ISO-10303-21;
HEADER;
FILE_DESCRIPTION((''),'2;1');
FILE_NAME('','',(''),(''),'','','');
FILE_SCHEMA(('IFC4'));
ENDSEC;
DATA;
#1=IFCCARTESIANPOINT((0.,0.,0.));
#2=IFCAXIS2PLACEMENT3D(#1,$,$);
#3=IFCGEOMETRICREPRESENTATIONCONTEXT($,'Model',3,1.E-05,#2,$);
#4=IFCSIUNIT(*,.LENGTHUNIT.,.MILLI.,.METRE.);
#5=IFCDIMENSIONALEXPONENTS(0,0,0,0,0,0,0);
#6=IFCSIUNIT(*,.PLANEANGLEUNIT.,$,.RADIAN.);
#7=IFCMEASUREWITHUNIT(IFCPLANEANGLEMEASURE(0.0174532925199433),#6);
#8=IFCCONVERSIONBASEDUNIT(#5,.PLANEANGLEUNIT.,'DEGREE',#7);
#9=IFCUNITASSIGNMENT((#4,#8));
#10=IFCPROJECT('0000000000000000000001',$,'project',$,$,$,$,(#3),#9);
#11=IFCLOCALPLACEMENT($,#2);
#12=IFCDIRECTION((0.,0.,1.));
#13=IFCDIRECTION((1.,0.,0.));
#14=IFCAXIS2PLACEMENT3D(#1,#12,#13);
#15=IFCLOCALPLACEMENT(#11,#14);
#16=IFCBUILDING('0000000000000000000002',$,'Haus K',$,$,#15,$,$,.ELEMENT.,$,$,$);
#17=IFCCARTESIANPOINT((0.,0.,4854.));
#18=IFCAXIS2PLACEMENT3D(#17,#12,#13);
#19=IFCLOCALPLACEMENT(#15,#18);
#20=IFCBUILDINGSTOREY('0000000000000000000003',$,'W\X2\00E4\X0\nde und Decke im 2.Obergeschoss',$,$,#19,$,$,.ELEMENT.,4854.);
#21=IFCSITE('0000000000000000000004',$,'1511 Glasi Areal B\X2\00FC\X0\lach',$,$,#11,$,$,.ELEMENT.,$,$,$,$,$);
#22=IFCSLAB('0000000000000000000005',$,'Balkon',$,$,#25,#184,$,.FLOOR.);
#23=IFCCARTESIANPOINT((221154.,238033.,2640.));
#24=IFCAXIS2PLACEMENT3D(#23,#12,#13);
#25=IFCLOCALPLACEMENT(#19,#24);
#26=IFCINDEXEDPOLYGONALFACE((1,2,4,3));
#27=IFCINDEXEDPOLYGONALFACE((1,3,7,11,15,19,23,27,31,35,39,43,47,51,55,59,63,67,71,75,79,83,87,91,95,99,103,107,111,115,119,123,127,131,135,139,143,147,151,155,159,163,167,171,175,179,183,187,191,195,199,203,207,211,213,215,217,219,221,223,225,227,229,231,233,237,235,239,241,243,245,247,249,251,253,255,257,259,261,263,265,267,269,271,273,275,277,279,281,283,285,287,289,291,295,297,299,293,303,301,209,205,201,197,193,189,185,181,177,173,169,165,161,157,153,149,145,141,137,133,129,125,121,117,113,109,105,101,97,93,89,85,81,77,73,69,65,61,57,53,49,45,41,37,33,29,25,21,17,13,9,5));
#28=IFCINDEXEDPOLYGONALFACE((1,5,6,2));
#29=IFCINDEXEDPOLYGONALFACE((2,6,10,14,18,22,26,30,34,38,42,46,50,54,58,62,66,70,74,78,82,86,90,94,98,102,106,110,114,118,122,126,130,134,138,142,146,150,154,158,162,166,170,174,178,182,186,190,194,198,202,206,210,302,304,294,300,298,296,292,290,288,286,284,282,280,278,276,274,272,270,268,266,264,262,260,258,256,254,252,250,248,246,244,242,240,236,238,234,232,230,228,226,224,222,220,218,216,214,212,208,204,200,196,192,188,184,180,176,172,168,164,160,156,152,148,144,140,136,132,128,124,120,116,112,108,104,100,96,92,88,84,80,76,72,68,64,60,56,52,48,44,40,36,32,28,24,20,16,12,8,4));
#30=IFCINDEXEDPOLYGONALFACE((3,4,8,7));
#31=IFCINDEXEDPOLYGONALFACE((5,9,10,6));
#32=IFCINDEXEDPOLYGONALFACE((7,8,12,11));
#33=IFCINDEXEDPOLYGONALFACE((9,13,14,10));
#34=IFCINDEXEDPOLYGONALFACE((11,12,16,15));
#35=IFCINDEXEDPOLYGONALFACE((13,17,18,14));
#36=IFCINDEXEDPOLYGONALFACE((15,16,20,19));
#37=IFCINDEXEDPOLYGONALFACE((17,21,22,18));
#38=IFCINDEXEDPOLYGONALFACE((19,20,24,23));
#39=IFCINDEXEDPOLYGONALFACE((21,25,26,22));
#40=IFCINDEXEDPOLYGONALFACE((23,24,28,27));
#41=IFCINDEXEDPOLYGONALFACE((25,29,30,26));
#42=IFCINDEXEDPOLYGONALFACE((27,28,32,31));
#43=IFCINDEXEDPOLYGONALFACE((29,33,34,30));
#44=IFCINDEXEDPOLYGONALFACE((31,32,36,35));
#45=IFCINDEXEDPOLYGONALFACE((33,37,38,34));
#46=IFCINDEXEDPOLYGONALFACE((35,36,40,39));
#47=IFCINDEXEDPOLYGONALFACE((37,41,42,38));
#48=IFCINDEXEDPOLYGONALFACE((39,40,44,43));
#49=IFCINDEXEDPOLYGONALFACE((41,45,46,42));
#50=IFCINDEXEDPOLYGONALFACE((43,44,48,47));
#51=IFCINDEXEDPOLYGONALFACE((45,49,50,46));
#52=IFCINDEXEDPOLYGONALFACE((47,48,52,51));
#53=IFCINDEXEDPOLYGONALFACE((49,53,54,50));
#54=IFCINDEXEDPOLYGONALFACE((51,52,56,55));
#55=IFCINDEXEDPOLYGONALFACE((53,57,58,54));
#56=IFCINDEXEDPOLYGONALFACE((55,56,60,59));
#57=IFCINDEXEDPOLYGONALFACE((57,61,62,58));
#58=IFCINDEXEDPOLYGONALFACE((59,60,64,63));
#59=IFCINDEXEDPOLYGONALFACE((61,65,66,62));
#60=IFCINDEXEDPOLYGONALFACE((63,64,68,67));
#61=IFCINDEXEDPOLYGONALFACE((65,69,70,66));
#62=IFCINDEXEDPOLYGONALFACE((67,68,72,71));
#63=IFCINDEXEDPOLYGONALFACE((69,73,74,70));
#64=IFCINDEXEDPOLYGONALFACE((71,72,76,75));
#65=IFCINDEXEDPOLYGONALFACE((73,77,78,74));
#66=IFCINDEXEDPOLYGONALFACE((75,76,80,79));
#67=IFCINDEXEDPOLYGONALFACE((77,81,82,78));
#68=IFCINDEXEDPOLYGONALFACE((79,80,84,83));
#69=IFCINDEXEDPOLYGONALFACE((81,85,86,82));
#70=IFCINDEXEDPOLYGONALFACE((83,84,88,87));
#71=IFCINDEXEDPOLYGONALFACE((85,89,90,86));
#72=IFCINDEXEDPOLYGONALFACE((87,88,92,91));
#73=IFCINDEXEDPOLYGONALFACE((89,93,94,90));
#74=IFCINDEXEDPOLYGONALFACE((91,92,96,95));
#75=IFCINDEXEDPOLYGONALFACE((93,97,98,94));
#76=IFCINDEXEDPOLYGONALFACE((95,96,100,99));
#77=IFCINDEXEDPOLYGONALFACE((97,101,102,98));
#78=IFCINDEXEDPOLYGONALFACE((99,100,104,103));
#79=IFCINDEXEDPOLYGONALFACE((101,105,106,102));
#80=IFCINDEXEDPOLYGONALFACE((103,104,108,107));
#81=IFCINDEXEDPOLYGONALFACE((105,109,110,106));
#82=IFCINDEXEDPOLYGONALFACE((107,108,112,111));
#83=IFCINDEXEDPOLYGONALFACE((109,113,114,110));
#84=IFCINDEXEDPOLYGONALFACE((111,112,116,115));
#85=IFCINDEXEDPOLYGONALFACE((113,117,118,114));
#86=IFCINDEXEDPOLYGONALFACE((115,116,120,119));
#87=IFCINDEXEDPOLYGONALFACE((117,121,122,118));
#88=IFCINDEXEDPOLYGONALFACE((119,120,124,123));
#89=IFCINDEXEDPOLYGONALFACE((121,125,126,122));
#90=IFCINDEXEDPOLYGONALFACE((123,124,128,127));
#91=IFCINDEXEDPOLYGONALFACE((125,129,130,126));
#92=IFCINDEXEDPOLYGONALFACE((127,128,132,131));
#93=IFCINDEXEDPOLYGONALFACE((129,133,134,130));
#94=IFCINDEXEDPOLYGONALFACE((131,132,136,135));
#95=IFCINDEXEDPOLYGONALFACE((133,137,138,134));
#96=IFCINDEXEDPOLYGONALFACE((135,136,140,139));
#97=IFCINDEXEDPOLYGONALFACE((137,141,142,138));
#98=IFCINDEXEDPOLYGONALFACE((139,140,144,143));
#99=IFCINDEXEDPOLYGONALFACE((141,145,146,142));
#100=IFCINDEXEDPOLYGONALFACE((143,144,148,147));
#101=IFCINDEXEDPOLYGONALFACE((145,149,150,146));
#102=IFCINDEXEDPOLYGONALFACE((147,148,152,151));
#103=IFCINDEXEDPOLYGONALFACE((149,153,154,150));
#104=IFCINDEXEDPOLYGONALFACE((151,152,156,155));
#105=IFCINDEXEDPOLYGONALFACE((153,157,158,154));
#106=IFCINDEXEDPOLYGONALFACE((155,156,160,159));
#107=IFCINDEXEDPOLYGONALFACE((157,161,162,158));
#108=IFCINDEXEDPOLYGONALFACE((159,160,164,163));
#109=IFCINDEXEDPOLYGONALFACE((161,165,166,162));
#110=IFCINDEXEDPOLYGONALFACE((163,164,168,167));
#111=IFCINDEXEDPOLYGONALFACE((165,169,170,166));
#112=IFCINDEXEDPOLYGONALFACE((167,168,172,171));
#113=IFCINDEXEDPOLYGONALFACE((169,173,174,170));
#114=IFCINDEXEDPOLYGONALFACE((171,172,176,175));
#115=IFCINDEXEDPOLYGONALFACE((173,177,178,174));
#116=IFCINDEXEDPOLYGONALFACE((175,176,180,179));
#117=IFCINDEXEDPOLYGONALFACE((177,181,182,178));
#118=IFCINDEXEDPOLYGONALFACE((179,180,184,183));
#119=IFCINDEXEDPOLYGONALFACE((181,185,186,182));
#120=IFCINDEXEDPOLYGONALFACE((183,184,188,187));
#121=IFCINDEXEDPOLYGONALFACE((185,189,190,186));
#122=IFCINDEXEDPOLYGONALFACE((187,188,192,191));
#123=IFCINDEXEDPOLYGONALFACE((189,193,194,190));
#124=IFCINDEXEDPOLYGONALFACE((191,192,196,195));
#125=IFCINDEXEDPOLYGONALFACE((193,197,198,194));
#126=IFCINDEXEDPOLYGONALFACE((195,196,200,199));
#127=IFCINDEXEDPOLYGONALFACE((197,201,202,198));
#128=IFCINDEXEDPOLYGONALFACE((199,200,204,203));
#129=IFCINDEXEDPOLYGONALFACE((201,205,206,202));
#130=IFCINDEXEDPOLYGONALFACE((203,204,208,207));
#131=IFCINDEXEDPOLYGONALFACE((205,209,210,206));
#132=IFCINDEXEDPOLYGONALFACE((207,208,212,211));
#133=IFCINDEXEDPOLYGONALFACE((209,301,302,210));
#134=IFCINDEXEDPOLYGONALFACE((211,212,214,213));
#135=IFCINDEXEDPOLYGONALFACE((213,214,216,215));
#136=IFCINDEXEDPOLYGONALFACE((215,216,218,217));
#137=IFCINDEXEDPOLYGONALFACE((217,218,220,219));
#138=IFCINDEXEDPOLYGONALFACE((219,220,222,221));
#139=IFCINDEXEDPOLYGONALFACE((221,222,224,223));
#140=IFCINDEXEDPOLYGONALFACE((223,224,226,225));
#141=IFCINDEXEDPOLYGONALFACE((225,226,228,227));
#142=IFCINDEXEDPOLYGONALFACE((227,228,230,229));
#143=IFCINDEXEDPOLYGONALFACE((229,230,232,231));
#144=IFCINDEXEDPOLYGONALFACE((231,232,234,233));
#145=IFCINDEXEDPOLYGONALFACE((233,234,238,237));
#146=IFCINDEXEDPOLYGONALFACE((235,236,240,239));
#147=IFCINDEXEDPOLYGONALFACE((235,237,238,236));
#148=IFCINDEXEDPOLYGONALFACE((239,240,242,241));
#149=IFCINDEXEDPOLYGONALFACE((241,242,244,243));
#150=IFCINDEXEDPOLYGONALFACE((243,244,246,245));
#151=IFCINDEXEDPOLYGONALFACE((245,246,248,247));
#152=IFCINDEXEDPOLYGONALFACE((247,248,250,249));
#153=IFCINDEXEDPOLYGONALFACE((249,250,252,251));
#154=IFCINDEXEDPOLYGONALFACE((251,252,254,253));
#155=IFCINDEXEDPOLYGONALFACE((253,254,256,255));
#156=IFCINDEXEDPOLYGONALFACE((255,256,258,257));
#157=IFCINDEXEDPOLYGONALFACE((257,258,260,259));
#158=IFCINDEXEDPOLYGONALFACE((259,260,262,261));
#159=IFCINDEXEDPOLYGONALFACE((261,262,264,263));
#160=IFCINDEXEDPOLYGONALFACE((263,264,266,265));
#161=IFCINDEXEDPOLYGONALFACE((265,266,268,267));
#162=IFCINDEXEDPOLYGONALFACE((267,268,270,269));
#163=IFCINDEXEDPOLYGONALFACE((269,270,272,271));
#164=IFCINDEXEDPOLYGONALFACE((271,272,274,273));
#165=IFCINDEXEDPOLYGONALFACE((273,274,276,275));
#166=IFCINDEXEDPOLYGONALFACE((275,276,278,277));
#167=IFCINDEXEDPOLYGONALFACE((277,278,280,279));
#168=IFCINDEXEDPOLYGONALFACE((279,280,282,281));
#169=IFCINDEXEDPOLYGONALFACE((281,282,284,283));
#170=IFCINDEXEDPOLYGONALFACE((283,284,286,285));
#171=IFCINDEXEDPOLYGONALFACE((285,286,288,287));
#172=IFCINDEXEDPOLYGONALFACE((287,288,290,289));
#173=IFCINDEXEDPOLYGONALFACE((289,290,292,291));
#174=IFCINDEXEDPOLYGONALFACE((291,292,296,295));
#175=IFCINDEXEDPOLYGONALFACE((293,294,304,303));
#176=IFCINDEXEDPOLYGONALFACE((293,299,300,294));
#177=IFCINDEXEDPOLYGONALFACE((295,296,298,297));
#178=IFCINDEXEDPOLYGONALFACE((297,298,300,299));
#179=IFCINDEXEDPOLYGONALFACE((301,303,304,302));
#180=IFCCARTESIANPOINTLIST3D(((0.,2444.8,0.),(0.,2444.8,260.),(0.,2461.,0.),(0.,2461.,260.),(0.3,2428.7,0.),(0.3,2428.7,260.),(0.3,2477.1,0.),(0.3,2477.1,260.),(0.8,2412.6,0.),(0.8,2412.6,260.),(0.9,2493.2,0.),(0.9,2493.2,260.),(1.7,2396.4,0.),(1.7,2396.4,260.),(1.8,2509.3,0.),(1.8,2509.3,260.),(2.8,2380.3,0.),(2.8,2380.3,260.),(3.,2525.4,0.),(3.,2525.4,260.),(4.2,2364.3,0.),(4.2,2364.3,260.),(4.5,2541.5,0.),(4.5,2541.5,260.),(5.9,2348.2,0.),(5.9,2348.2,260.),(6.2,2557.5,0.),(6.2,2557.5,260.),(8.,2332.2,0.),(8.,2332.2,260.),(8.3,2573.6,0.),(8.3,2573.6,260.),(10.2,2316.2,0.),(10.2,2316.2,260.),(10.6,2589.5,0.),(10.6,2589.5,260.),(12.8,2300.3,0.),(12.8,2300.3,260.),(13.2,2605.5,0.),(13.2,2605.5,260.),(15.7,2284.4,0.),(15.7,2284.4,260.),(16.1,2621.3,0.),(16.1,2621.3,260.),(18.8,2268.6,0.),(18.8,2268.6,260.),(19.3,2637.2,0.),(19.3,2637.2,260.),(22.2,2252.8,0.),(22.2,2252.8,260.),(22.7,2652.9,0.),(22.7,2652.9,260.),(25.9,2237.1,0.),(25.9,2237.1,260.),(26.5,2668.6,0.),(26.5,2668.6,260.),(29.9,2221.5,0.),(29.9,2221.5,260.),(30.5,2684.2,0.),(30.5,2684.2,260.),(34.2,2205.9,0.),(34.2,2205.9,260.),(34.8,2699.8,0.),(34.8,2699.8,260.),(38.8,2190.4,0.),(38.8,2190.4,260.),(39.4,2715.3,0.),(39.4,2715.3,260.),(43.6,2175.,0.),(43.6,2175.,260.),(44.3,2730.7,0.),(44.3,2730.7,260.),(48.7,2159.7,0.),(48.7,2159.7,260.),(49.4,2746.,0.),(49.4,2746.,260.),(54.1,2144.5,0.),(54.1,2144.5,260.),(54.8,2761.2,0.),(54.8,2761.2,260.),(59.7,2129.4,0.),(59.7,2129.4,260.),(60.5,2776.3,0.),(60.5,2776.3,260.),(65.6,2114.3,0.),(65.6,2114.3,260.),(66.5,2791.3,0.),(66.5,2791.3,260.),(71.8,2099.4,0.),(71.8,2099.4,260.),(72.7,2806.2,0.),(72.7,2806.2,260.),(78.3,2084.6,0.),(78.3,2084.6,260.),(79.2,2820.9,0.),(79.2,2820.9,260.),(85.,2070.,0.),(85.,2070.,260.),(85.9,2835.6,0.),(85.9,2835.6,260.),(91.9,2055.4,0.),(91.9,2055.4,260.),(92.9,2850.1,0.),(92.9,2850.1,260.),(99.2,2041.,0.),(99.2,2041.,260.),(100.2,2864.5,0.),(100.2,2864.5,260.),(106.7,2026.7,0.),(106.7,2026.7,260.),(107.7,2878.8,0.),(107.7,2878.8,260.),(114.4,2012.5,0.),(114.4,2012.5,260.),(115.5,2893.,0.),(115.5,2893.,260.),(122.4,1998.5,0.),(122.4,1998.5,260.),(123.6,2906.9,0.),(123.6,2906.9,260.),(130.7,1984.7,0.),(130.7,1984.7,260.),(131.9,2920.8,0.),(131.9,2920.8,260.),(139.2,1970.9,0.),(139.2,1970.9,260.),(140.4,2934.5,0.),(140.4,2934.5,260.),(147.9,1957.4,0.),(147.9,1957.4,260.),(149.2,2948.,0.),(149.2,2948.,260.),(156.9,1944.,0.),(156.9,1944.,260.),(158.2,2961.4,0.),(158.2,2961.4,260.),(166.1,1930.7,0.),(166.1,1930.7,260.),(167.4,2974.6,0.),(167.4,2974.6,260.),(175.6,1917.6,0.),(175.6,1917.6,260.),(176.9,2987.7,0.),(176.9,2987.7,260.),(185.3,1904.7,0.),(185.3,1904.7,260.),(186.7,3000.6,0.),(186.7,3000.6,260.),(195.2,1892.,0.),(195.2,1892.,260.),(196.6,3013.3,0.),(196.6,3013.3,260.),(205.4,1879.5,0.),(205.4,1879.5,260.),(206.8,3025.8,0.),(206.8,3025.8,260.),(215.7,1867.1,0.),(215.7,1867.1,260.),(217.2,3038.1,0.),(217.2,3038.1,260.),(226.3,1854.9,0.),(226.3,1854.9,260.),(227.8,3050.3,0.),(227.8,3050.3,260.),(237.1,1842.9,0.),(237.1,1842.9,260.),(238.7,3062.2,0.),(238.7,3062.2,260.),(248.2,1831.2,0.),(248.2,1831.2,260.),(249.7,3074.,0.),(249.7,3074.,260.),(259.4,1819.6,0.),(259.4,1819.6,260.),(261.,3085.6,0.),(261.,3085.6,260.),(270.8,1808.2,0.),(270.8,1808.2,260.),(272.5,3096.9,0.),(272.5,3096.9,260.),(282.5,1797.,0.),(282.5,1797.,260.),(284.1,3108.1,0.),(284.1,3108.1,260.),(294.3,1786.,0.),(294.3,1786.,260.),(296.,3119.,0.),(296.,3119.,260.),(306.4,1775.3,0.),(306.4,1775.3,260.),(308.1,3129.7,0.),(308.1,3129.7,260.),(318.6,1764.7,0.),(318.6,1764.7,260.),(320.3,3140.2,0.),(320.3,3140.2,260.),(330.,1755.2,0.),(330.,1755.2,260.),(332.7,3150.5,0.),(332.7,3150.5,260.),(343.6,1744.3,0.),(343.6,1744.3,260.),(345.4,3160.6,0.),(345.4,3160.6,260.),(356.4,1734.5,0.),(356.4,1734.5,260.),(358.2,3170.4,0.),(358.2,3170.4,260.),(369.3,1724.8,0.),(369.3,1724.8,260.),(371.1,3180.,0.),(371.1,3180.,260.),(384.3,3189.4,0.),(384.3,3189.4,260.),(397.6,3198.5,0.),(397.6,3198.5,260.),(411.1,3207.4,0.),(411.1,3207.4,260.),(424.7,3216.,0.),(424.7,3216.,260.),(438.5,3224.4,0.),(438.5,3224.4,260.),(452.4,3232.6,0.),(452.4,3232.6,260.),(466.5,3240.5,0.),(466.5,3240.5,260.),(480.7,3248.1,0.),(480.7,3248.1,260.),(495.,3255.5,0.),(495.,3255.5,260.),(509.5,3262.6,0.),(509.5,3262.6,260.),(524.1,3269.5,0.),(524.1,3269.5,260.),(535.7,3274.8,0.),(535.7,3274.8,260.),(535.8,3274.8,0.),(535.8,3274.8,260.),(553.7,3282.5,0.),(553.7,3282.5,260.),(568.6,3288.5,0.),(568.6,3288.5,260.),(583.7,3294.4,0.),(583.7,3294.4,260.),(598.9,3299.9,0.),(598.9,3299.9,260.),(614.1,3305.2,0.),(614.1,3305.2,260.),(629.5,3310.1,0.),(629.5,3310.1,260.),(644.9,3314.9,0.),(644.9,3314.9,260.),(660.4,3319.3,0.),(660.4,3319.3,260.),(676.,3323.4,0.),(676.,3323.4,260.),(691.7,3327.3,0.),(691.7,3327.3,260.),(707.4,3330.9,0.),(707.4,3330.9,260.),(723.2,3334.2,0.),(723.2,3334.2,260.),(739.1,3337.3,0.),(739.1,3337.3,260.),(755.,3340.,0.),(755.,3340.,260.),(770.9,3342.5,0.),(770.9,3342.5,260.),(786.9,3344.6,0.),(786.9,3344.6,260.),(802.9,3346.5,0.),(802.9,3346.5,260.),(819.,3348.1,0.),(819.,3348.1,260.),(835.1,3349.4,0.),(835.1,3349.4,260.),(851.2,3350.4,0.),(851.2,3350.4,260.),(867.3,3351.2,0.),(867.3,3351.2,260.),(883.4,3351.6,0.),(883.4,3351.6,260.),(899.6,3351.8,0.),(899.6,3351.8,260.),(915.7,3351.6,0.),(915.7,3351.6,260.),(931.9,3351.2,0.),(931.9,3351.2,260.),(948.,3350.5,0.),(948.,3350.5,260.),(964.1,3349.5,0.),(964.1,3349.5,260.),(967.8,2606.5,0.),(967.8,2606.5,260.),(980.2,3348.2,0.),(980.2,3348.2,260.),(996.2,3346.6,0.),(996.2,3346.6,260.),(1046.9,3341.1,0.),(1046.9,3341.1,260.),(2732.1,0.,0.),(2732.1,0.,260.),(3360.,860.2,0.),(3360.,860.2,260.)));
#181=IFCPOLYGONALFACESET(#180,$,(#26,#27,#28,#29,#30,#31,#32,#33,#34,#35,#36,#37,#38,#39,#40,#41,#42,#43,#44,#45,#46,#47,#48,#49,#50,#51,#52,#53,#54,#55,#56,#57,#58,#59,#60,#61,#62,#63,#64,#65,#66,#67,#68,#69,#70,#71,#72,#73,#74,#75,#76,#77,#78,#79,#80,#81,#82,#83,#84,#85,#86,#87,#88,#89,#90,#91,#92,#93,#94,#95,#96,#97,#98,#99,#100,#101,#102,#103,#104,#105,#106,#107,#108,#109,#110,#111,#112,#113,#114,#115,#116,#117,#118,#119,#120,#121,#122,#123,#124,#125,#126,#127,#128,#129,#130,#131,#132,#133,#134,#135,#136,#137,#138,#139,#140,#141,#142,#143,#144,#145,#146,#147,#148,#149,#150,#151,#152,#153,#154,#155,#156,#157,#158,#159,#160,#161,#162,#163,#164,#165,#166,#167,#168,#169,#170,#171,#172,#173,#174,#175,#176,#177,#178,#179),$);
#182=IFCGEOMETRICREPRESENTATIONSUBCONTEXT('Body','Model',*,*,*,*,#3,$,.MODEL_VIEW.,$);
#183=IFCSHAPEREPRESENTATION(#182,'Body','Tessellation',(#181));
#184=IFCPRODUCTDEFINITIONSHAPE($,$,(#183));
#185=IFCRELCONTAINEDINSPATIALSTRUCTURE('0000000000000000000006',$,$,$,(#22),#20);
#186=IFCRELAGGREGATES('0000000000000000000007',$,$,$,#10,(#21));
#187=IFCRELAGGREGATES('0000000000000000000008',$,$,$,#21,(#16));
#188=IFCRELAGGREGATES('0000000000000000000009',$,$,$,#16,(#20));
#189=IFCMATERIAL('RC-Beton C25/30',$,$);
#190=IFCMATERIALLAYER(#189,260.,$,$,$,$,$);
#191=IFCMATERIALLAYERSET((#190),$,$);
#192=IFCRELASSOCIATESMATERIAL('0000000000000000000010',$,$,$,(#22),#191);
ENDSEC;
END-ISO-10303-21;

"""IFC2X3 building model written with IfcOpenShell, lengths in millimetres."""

from ifc_helpers import new_model, entity, si_unit, converted_unit, frame, origin, origin_with_axes, place, context, subcontext, project, spatial, polyline, outline, extrude, material, layer, layer_set, layer_usage, element, save


model = new_model("IFC2X3")

# Units and contexts
model_context = context("Model", 3, precision=1e-05, world=origin())
body_context = subcontext(model_context, "Body", "Model", "MODEL_VIEW")
ifc_project = project(units=[si_unit("LENGTHUNIT", "METRE", prefix="MILLI"), converted_unit("PLANEANGLEUNIT", "DEGREE", entity("IfcPlaneAngleMeasure", 0.0174532925199433), si_unit("PLANEANGLEUNIT", "RADIAN"), dimensions=[0, 0, 0, 0, 0, 0, 0])], contexts=[model_context])

# Site, building, storey
site_placement = place(None, origin())
site = spatial("IfcSite", under=ifc_project, at=site_placement, Name="1511 Glasi Areal Bülach", CompositionType="ELEMENT")
building_placement = place(site_placement, origin_with_axes())
building = spatial("IfcBuilding", under=site, at=building_placement, Name="Haus K", CompositionType="ELEMENT")
storey_placement = place(building_placement, frame((0.0, 0.0, 4854.0), z_axis=(0.0, 0.0, 1.0), x_axis=(1.0, 0.0, 0.0)))
storey = spatial("IfcBuildingStorey", under=building, at=storey_placement, Name="Wände und Decke im 2.Obergeschoss", CompositionType="ELEMENT", Elevation=4854.0)

# Slab
ifc_material_1 = material(Name="RC-Beton C25/30")
ifc_layer_1 = layer(ifc_material_1, 260.0)
ifc_layer_set_1 = layer_set([ifc_layer_1])
ifc_layer_usage_1 = layer_usage(ifc_layer_set_1, "AXIS3", "POSITIVE", 0.0)
slab_1_placement = place(storey_placement, frame((221154.0, 238033.0, 2640.0), z_axis=(0.0, 0.0, 1.0), x_axis=(1.0, 0.0, 0.0)))
element("IfcSlab", 1, at=slab_1_placement, inside=storey, material=ifc_layer_usage_1, Name="Balkon", PredefinedType="FLOOR", context=body_context, shape_type="SweptSolid", body=[
    extrude(outline(polyline([(996.2, 3346.6), (980.2, 3348.2), (964.1, 3349.5), (948.0, 3350.5), (931.9, 3351.2), (915.7, 3351.6), (899.6, 3351.8), (883.4, 3351.6), (867.3, 3351.2), (851.2, 3350.4), (835.1, 3349.4), (819.0, 3348.1), (802.9, 3346.5), (786.9, 3344.6), (770.9, 3342.5), (755.0, 3340.0), (739.1, 3337.3), (723.2, 3334.2), (707.4, 3330.9), (691.7, 3327.3), (676.0, 3323.4), (660.4, 3319.3), (644.9, 3314.9), (629.5, 3310.1), (614.1, 3305.2), (598.9, 3299.9), (583.7, 3294.4), (568.6, 3288.5), (553.7, 3282.5), (535.7, 3274.8), (535.8, 3274.8), (524.1, 3269.5), (509.5, 3262.6), (495.0, 3255.5), (480.7, 3248.1), (466.5, 3240.5), (452.4, 3232.6), (438.5, 3224.4), (424.7, 3216.0), (411.1, 3207.4), (397.6, 3198.5), (384.3, 3189.4), (371.1, 3180.0), (358.2, 3170.4), (345.4, 3160.6), (332.7, 3150.5), (320.3, 3140.2), (308.1, 3129.7), (296.0, 3119.0), (284.1, 3108.1), (272.5, 3096.9), (261.0, 3085.6), (249.7, 3074.0), (238.7, 3062.2), (227.8, 3050.3), (217.2, 3038.1), (206.8, 3025.8), (196.6, 3013.3), (186.7, 3000.6), (176.9, 2987.7), (167.4, 2974.6), (158.2, 2961.4), (149.2, 2948.0), (140.4, 2934.5), (131.9, 2920.8), (123.6, 2906.9), (115.5, 2893.0), (107.7, 2878.8), (100.2, 2864.5), (92.9, 2850.1), (85.9, 2835.6), (79.2, 2820.9), (72.7, 2806.2), (66.5, 2791.3), (60.5, 2776.3), (54.8, 2761.2), (49.4, 2746.0), (44.3, 2730.7), (39.4, 2715.3), (34.8, 2699.8), (30.5, 2684.2), (26.5, 2668.6), (22.7, 2652.9), (19.3, 2637.2), (16.1, 2621.3), (13.2, 2605.5), (10.6, 2589.5), (8.3, 2573.6), (6.2, 2557.5), (4.5, 2541.5), (3.0, 2525.4), (1.8, 2509.3), (0.9, 2493.2), (0.3, 2477.1), (0.0, 2461.0), (0.0, 2444.8), (0.3, 2428.7), (0.8, 2412.6), (1.7, 2396.4), (2.8, 2380.3), (4.2, 2364.3), (5.9, 2348.2), (8.0, 2332.2), (10.2, 2316.2), (12.8, 2300.3), (15.7, 2284.4), (18.8, 2268.6), (22.2, 2252.8), (25.9, 2237.1), (29.9, 2221.5), (34.2, 2205.9), (38.8, 2190.4), (43.6, 2175.0), (48.7, 2159.7), (54.1, 2144.5), (59.7, 2129.4), (65.6, 2114.3), (71.8, 2099.4), (78.3, 2084.6), (85.0, 2070.0), (91.9, 2055.4), (99.2, 2041.0), (106.7, 2026.7), (114.4, 2012.5), (122.4, 1998.5), (130.7, 1984.7), (139.2, 1970.9), (147.9, 1957.4), (156.9, 1944.0), (166.1, 1930.7), (175.6, 1917.6), (185.3, 1904.7), (195.2, 1892.0), (205.4, 1879.5), (215.7, 1867.1), (226.3, 1854.9), (237.1, 1842.9), (248.2, 1831.2), (259.4, 1819.6), (270.8, 1808.2), (282.5, 1797.0), (294.3, 1786.0), (306.4, 1775.3), (318.6, 1764.7), (330.0, 1755.2), (330.0, 1755.2), (343.6, 1744.3), (356.4, 1734.5), (369.3, 1724.8), (2732.1, 0.0), (3360.0, 860.2), (967.8, 2606.5), (1046.9, 3341.1), (996.2, 3346.6)])), origin_with_axes(), (0.0, 0.0, 1.0), 260.0),
])

save(model, "model.ifc")
